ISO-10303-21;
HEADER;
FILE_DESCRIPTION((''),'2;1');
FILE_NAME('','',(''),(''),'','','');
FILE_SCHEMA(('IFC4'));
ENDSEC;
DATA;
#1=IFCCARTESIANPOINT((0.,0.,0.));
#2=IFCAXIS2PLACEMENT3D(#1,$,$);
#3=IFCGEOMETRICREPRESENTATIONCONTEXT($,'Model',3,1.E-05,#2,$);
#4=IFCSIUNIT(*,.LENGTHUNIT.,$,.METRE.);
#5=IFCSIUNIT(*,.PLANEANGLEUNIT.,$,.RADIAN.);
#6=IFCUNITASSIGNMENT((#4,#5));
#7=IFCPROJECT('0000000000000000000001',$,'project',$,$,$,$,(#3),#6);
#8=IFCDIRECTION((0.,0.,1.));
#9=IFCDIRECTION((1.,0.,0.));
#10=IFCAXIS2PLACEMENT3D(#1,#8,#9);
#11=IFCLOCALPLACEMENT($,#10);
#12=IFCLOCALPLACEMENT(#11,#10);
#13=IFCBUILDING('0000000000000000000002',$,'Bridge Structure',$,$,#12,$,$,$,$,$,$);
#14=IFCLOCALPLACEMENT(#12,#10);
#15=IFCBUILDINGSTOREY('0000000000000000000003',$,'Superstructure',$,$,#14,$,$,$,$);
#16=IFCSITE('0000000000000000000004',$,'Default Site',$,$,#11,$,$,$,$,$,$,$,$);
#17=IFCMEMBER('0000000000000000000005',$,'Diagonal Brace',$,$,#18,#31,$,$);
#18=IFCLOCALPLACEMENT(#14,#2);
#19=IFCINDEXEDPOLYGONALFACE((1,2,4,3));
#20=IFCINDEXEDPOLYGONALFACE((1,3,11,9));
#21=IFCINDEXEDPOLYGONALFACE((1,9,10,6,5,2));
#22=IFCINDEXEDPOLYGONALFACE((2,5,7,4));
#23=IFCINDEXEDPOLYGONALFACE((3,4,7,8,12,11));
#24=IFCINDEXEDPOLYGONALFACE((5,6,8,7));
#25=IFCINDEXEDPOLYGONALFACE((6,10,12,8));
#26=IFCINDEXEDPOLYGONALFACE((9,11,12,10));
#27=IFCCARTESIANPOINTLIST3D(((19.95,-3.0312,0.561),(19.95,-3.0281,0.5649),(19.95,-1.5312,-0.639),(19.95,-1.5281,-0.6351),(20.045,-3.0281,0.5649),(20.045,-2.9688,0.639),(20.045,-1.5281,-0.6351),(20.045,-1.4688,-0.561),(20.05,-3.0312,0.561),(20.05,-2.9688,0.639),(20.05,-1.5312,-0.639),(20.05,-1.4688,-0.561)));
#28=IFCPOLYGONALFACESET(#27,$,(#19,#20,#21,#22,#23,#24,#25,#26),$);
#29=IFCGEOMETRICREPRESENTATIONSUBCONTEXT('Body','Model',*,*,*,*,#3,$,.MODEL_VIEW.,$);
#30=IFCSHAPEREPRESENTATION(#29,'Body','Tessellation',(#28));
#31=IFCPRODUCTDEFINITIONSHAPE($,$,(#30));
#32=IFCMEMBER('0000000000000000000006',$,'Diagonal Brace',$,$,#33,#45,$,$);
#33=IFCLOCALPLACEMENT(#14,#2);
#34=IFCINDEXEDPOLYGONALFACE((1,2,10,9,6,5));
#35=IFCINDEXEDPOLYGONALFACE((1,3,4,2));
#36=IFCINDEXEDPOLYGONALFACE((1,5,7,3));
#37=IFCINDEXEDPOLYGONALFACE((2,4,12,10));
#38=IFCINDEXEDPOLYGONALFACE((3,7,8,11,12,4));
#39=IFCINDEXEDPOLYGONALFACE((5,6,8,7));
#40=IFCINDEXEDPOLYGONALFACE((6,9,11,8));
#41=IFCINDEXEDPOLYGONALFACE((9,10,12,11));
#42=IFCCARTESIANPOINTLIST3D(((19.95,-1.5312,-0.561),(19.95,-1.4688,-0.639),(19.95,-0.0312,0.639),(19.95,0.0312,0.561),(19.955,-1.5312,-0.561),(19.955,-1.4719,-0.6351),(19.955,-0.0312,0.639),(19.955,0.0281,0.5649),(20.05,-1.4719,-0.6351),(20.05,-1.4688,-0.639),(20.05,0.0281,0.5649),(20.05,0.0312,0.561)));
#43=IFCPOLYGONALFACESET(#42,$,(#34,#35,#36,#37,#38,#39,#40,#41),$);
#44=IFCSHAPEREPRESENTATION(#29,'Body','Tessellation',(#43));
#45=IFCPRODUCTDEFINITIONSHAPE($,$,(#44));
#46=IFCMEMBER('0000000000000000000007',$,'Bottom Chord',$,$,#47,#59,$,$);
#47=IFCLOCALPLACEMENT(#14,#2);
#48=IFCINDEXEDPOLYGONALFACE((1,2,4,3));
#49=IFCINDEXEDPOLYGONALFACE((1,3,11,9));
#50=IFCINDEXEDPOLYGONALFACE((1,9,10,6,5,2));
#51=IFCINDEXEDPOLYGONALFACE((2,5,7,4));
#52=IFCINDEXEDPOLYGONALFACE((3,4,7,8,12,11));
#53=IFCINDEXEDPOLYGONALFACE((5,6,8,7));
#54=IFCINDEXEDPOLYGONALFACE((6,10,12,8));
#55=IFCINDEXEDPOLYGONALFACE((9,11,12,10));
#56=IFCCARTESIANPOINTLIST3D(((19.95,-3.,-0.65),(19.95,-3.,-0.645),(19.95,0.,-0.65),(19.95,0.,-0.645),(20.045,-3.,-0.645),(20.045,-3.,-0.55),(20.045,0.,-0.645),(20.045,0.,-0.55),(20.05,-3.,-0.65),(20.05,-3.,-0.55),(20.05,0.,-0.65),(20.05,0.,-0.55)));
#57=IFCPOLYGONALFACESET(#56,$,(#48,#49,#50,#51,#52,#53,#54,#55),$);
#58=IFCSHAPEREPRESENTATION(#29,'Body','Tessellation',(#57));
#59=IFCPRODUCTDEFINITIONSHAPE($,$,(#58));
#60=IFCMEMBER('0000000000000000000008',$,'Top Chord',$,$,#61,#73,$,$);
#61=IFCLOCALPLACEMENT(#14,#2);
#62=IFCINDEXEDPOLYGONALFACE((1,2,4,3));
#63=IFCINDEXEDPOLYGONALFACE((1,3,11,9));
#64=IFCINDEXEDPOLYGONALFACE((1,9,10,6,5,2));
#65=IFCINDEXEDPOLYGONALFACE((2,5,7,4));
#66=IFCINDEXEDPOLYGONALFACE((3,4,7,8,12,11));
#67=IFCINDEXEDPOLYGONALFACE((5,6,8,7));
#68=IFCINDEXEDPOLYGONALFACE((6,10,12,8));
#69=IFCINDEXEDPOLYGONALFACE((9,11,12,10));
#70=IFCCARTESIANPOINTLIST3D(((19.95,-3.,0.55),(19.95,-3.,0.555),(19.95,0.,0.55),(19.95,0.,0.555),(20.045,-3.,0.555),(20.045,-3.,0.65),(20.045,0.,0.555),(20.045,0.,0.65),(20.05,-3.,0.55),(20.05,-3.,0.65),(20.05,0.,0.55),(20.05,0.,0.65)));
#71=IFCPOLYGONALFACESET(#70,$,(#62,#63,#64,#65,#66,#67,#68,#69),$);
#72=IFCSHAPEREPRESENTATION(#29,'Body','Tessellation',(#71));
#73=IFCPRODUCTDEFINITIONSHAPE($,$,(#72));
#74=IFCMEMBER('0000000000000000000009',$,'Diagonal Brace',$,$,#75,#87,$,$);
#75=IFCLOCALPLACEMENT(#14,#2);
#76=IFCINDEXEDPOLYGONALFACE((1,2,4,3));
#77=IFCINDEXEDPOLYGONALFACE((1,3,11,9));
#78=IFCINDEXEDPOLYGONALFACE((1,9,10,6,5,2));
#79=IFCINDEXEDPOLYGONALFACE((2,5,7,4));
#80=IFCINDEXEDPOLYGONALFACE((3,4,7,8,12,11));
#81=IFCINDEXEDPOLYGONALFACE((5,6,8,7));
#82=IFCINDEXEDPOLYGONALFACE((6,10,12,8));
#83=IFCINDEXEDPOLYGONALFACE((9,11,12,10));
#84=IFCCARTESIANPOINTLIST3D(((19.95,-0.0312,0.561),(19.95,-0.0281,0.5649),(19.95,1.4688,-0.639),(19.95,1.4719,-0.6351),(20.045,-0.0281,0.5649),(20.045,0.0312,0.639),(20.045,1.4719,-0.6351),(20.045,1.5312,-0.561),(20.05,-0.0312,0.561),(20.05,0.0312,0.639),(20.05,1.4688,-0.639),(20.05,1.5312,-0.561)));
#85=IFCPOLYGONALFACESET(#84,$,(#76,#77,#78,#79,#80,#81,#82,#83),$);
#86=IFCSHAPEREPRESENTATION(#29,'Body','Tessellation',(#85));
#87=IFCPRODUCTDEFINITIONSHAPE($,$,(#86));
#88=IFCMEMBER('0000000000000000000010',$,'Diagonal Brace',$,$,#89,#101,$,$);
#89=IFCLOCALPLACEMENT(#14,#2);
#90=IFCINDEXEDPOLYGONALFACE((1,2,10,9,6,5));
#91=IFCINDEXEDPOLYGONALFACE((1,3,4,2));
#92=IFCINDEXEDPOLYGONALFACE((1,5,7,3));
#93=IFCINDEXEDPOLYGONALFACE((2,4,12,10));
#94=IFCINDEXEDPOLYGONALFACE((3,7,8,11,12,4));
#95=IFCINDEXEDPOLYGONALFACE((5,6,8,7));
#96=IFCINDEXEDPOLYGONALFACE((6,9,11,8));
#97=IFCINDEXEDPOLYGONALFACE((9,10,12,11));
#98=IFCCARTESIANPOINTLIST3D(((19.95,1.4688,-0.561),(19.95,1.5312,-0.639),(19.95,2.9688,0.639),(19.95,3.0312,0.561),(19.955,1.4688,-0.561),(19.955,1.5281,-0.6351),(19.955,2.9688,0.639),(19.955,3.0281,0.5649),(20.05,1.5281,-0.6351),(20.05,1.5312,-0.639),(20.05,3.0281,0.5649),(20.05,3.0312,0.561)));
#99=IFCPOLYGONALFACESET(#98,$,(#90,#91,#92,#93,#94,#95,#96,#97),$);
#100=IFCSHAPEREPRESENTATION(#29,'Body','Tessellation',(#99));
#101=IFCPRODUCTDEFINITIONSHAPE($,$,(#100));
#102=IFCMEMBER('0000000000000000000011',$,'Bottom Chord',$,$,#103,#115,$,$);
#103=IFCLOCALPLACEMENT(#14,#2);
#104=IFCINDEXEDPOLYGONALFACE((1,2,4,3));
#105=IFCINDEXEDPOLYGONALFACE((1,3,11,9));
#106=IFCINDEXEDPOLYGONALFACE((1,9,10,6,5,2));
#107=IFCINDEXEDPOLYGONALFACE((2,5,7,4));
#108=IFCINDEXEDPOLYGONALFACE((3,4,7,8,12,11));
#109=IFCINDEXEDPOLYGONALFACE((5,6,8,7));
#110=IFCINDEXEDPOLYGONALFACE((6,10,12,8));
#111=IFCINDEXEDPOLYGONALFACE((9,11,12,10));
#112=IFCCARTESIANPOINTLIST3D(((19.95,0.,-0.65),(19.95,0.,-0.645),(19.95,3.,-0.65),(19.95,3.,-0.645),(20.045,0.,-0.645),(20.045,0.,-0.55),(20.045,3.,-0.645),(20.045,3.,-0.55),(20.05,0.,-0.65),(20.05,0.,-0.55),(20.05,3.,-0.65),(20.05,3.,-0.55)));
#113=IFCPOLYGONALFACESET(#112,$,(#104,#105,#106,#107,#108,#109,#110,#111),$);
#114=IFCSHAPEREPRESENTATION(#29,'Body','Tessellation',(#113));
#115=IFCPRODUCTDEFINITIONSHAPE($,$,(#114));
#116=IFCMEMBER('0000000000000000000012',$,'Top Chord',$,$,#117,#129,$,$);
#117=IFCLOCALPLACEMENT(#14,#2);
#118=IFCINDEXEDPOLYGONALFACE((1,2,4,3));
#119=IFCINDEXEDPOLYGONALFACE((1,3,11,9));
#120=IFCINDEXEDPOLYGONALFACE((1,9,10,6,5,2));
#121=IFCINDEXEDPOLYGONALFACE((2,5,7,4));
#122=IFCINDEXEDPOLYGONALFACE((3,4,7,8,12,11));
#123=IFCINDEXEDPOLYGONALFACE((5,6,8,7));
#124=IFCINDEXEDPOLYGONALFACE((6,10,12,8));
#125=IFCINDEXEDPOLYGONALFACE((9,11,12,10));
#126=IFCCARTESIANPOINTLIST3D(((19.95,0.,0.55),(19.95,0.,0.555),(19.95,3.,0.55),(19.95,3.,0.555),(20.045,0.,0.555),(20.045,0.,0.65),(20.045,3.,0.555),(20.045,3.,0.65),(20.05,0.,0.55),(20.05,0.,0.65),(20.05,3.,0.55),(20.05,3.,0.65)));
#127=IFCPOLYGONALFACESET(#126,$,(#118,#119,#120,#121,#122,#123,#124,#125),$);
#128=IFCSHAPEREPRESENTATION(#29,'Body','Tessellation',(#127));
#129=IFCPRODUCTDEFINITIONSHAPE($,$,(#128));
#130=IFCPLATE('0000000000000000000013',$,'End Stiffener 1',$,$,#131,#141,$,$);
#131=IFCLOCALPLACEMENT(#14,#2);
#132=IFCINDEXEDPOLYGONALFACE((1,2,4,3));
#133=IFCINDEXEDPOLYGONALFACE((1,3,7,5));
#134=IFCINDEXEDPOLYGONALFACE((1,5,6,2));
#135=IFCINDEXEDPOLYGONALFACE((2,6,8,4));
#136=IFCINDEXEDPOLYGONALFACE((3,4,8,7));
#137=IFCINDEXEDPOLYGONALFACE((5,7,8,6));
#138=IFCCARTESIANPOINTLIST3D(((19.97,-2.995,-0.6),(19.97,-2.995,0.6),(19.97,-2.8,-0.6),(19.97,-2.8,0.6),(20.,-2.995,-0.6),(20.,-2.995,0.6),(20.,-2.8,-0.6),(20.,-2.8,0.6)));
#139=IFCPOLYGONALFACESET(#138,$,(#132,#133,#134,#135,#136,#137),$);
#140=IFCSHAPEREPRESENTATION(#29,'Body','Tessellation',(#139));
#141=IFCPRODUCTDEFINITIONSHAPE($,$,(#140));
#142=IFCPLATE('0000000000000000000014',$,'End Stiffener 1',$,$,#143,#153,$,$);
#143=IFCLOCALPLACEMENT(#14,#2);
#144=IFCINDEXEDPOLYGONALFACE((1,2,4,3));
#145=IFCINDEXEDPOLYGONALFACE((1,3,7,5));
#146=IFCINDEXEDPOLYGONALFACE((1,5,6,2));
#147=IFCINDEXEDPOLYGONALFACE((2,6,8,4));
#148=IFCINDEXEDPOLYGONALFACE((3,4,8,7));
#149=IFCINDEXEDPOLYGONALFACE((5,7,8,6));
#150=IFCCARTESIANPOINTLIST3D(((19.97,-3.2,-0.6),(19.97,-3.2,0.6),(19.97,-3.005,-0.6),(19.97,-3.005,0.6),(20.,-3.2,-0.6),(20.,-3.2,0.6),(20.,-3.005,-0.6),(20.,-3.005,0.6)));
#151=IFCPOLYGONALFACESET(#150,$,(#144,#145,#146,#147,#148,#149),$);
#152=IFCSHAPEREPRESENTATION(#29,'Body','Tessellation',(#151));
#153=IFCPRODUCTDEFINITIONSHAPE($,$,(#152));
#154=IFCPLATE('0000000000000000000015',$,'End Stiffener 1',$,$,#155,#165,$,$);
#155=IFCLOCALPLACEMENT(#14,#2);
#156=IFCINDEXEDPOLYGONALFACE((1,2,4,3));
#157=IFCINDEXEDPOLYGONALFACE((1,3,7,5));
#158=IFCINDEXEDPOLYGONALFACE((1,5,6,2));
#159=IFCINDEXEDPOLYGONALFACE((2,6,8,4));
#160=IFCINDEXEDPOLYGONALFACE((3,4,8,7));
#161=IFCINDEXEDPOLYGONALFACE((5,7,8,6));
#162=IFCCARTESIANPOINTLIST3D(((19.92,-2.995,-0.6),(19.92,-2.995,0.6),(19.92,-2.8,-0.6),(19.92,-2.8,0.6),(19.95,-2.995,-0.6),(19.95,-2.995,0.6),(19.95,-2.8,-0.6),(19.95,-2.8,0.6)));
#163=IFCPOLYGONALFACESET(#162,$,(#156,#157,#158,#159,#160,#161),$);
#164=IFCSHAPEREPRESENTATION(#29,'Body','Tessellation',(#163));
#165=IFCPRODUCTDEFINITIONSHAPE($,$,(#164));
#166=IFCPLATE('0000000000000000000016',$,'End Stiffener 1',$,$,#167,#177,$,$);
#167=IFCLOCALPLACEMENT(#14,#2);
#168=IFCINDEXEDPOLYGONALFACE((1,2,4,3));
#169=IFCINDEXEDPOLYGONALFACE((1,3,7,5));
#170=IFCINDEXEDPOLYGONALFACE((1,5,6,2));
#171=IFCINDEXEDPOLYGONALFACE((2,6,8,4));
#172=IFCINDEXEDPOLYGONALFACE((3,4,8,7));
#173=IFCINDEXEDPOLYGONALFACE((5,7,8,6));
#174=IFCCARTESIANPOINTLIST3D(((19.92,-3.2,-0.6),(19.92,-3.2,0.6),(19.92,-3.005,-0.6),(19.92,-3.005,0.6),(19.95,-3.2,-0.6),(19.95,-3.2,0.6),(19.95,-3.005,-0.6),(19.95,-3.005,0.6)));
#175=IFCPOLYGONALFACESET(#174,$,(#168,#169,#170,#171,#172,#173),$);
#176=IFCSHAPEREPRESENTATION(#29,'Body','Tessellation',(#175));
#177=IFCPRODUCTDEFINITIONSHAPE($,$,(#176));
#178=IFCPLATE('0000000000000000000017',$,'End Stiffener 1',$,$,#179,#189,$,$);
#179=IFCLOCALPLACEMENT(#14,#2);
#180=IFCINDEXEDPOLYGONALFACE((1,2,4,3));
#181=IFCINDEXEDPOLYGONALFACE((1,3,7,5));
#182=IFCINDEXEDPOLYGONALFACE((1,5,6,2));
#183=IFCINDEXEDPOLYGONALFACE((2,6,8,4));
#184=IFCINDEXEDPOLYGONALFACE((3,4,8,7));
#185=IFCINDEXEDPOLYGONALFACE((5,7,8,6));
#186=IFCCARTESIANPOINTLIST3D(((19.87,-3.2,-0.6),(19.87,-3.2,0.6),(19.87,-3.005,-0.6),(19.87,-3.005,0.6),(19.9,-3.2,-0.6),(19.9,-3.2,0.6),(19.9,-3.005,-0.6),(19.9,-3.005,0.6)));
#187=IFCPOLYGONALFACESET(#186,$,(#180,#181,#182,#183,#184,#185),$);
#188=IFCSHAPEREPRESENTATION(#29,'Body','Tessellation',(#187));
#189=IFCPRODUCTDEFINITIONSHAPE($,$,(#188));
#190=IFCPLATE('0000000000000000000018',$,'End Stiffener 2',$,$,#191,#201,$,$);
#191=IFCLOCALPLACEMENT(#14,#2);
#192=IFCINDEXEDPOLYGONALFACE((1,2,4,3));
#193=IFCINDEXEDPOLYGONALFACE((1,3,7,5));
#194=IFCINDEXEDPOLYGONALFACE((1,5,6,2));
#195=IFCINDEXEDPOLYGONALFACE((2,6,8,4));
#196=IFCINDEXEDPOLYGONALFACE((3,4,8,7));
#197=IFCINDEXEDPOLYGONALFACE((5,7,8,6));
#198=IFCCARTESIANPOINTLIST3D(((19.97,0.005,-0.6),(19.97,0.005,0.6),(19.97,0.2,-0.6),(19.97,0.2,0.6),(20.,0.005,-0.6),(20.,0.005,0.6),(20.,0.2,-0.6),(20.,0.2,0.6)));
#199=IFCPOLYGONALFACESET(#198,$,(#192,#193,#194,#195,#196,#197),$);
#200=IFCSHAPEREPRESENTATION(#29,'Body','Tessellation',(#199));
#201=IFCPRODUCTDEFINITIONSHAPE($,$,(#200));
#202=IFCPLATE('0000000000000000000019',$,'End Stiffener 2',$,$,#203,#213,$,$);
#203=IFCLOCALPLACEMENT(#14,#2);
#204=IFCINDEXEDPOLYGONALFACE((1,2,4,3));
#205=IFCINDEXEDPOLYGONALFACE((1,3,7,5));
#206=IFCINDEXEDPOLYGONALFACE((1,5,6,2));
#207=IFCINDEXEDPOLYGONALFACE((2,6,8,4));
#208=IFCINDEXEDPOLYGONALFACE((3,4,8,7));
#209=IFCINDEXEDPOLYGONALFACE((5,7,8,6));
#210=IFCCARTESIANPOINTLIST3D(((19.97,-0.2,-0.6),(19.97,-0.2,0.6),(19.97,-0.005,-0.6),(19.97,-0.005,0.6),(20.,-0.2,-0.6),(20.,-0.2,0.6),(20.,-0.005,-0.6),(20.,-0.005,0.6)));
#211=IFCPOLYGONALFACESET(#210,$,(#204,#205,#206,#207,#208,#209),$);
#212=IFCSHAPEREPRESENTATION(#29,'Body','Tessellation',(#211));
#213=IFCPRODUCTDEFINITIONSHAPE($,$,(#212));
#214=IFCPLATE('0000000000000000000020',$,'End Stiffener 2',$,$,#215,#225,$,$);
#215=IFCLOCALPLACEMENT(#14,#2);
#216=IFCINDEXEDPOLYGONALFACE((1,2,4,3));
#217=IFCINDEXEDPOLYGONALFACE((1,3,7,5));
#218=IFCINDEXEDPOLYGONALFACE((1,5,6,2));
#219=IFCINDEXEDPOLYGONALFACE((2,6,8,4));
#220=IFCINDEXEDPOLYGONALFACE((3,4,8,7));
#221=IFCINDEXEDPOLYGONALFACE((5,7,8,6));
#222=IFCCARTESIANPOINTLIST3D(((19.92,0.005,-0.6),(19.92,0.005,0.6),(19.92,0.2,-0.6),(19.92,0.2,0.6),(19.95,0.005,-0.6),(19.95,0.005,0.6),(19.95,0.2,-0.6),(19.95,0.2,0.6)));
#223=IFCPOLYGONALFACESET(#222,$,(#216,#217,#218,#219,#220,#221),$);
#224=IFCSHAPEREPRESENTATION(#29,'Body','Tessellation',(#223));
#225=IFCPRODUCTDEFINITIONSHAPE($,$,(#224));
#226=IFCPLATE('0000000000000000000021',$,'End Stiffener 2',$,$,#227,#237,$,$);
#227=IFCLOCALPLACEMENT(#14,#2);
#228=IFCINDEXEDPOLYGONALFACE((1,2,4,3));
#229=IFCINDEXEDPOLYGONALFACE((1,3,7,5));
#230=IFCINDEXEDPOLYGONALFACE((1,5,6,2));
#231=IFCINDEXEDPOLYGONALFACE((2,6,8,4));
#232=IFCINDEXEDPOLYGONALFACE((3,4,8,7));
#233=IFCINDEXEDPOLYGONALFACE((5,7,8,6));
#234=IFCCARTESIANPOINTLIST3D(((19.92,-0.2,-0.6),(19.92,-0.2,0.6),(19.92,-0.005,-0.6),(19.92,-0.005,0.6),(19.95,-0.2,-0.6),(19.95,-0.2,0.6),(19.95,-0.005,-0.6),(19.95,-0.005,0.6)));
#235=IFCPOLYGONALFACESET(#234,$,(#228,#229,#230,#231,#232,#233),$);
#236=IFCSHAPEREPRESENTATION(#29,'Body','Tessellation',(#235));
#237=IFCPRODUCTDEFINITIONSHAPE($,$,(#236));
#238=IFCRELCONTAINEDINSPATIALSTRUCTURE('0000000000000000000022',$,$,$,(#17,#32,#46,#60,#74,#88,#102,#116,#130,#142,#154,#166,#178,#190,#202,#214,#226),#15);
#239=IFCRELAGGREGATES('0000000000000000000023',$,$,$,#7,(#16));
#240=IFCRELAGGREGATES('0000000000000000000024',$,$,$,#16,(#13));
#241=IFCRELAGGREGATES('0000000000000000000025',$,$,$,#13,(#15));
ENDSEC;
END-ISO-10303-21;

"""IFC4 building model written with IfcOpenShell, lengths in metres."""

from ifc_helpers import new_model, si_unit, frame, origin, origin_with_axes, origin_2d_with_axis, place, context, subcontext, project, spatial, rectangle, l_section, extrude, element, save


model = new_model("IFC4")

# Units and contexts
model_context = context("Model", 3, precision=1e-05, world=origin())
body_context = subcontext(model_context, "Body", "Model", "MODEL_VIEW")
ifc_project = project(units=[si_unit("LENGTHUNIT", "METRE"), si_unit("PLANEANGLEUNIT", "RADIAN")], contexts=[model_context])

# Site, building, storey
site_placement = place(None, origin_with_axes())
site = spatial("IfcSite", under=ifc_project, at=site_placement, Name="Default Site")
building_placement = place(site_placement, origin_with_axes())
building = spatial("IfcBuilding", under=site, at=building_placement, Name="Bridge Structure")
storey_placement = place(building_placement, origin_with_axes())
storey = spatial("IfcBuildingStorey", under=building, at=storey_placement, Name="Superstructure")

# Members
for number, where, z_axis, x_axis, name in (
    (1, (20.0, -3.0, 0.6), (0.0, 0.780869, -0.624695), (-1.0, 0.0, 0.0), "Diagonal Brace"),
    (2, (20.0, 0.0, 0.6), (0.0, -0.780869, -0.624695), (1.0, 0.0, 0.0), "Diagonal Brace"),
):
    element("IfcMember", number, at=place(storey_placement, frame(where, z_axis=z_axis, x_axis=x_axis)), inside=storey, Name=name, context=body_context, shape_type="SweptSolid", body=[
        extrude(l_section(Depth=0.1, Width=0.1, Thickness=0.005, at=origin_2d_with_axis()), origin_with_axes(), (0.0, 0.0, 1.0), 1.9209),
    ])
for number, where, z_axis, x_axis, name in (
    (3, (20.0, -3.0, -0.6), (0.0, 1.0, 0.0), (-1.0, 0.0, 0.0), "Bottom Chord"),
    (4, (20.0, -3.0, 0.6), (0.0, 1.0, 0.0), (-1.0, 0.0, 0.0), "Top Chord"),
):
    element("IfcMember", number, at=place(storey_placement, frame(where, z_axis=z_axis, x_axis=x_axis)), inside=storey, Name=name, context=body_context, shape_type="SweptSolid", body=[
        extrude(l_section(Depth=0.1, Width=0.1, Thickness=0.005, at=origin_2d_with_axis()), origin_with_axes(), (0.0, 0.0, 1.0), 3.0),
    ])
for number, where, z_axis, x_axis, name in (
    (5, (20.0, 0.0, 0.6), (0.0, 0.780869, -0.624695), (-1.0, 0.0, 0.0), "Diagonal Brace"),
    (6, (20.0, 3.0, 0.6), (0.0, -0.780869, -0.624695), (1.0, 0.0, 0.0), "Diagonal Brace"),
):
    element("IfcMember", number, at=place(storey_placement, frame(where, z_axis=z_axis, x_axis=x_axis)), inside=storey, Name=name, context=body_context, shape_type="SweptSolid", body=[
        extrude(l_section(Depth=0.1, Width=0.1, Thickness=0.005, at=origin_2d_with_axis()), origin_with_axes(), (0.0, 0.0, 1.0), 1.9209),
    ])
for number, where, z_axis, x_axis, name in (
    (7, (20.0, 0.0, -0.6), (0.0, 1.0, 0.0), (-1.0, 0.0, 0.0), "Bottom Chord"),
    (8, (20.0, 0.0, 0.6), (0.0, 1.0, 0.0), (-1.0, 0.0, 0.0), "Top Chord"),
):
    element("IfcMember", number, at=place(storey_placement, frame(where, z_axis=z_axis, x_axis=x_axis)), inside=storey, Name=name, context=body_context, shape_type="SweptSolid", body=[
        extrude(l_section(Depth=0.1, Width=0.1, Thickness=0.005, at=origin_2d_with_axis()), origin_with_axes(), (0.0, 0.0, 1.0), 3.0),
    ])

# Plates
for number, where, z_axis, x_axis, name in (
    (9, (19.985, -2.8975, -0.6), (0.0, 0.0, 1.0), (1.0, 0.0, 0.0), "End Stiffener 1"),
    (10, (19.985, -3.1025, -0.6), (0.0, 0.0, 1.0), (1.0, 0.0, 0.0), "End Stiffener 1"),
    (11, (19.935, -2.8975, -0.6), (0.0, 0.0, 1.0), (1.0, 0.0, 0.0), "End Stiffener 1"),
    (12, (19.935, -3.1025, -0.6), (0.0, 0.0, 1.0), (1.0, 0.0, 0.0), "End Stiffener 1"),
    (13, (19.885, -3.1025, -0.6), (0.0, 0.0, 1.0), (1.0, 0.0, 0.0), "End Stiffener 1"),
    (14, (19.985, 0.1025, -0.6), (0.0, 0.0, 1.0), (1.0, 0.0, 0.0), "End Stiffener 2"),
    (15, (19.985, -0.1025, -0.6), (0.0, 0.0, 1.0), (1.0, 0.0, 0.0), "End Stiffener 2"),
    (16, (19.935, 0.1025, -0.6), (0.0, 0.0, 1.0), (1.0, 0.0, 0.0), "End Stiffener 2"),
    (17, (19.935, -0.1025, -0.6), (0.0, 0.0, 1.0), (1.0, 0.0, 0.0), "End Stiffener 2"),
):
    element("IfcPlate", number, at=place(storey_placement, frame(where, z_axis=z_axis, x_axis=x_axis)), inside=storey, Name=name, context=body_context, shape_type="SweptSolid", body=[
        extrude(rectangle(XDim=0.03, YDim=0.195, at=origin_2d_with_axis()), origin_with_axes(), (0.0, 0.0, 1.0), 1.2),
    ])

save(model, "model.ifc")
